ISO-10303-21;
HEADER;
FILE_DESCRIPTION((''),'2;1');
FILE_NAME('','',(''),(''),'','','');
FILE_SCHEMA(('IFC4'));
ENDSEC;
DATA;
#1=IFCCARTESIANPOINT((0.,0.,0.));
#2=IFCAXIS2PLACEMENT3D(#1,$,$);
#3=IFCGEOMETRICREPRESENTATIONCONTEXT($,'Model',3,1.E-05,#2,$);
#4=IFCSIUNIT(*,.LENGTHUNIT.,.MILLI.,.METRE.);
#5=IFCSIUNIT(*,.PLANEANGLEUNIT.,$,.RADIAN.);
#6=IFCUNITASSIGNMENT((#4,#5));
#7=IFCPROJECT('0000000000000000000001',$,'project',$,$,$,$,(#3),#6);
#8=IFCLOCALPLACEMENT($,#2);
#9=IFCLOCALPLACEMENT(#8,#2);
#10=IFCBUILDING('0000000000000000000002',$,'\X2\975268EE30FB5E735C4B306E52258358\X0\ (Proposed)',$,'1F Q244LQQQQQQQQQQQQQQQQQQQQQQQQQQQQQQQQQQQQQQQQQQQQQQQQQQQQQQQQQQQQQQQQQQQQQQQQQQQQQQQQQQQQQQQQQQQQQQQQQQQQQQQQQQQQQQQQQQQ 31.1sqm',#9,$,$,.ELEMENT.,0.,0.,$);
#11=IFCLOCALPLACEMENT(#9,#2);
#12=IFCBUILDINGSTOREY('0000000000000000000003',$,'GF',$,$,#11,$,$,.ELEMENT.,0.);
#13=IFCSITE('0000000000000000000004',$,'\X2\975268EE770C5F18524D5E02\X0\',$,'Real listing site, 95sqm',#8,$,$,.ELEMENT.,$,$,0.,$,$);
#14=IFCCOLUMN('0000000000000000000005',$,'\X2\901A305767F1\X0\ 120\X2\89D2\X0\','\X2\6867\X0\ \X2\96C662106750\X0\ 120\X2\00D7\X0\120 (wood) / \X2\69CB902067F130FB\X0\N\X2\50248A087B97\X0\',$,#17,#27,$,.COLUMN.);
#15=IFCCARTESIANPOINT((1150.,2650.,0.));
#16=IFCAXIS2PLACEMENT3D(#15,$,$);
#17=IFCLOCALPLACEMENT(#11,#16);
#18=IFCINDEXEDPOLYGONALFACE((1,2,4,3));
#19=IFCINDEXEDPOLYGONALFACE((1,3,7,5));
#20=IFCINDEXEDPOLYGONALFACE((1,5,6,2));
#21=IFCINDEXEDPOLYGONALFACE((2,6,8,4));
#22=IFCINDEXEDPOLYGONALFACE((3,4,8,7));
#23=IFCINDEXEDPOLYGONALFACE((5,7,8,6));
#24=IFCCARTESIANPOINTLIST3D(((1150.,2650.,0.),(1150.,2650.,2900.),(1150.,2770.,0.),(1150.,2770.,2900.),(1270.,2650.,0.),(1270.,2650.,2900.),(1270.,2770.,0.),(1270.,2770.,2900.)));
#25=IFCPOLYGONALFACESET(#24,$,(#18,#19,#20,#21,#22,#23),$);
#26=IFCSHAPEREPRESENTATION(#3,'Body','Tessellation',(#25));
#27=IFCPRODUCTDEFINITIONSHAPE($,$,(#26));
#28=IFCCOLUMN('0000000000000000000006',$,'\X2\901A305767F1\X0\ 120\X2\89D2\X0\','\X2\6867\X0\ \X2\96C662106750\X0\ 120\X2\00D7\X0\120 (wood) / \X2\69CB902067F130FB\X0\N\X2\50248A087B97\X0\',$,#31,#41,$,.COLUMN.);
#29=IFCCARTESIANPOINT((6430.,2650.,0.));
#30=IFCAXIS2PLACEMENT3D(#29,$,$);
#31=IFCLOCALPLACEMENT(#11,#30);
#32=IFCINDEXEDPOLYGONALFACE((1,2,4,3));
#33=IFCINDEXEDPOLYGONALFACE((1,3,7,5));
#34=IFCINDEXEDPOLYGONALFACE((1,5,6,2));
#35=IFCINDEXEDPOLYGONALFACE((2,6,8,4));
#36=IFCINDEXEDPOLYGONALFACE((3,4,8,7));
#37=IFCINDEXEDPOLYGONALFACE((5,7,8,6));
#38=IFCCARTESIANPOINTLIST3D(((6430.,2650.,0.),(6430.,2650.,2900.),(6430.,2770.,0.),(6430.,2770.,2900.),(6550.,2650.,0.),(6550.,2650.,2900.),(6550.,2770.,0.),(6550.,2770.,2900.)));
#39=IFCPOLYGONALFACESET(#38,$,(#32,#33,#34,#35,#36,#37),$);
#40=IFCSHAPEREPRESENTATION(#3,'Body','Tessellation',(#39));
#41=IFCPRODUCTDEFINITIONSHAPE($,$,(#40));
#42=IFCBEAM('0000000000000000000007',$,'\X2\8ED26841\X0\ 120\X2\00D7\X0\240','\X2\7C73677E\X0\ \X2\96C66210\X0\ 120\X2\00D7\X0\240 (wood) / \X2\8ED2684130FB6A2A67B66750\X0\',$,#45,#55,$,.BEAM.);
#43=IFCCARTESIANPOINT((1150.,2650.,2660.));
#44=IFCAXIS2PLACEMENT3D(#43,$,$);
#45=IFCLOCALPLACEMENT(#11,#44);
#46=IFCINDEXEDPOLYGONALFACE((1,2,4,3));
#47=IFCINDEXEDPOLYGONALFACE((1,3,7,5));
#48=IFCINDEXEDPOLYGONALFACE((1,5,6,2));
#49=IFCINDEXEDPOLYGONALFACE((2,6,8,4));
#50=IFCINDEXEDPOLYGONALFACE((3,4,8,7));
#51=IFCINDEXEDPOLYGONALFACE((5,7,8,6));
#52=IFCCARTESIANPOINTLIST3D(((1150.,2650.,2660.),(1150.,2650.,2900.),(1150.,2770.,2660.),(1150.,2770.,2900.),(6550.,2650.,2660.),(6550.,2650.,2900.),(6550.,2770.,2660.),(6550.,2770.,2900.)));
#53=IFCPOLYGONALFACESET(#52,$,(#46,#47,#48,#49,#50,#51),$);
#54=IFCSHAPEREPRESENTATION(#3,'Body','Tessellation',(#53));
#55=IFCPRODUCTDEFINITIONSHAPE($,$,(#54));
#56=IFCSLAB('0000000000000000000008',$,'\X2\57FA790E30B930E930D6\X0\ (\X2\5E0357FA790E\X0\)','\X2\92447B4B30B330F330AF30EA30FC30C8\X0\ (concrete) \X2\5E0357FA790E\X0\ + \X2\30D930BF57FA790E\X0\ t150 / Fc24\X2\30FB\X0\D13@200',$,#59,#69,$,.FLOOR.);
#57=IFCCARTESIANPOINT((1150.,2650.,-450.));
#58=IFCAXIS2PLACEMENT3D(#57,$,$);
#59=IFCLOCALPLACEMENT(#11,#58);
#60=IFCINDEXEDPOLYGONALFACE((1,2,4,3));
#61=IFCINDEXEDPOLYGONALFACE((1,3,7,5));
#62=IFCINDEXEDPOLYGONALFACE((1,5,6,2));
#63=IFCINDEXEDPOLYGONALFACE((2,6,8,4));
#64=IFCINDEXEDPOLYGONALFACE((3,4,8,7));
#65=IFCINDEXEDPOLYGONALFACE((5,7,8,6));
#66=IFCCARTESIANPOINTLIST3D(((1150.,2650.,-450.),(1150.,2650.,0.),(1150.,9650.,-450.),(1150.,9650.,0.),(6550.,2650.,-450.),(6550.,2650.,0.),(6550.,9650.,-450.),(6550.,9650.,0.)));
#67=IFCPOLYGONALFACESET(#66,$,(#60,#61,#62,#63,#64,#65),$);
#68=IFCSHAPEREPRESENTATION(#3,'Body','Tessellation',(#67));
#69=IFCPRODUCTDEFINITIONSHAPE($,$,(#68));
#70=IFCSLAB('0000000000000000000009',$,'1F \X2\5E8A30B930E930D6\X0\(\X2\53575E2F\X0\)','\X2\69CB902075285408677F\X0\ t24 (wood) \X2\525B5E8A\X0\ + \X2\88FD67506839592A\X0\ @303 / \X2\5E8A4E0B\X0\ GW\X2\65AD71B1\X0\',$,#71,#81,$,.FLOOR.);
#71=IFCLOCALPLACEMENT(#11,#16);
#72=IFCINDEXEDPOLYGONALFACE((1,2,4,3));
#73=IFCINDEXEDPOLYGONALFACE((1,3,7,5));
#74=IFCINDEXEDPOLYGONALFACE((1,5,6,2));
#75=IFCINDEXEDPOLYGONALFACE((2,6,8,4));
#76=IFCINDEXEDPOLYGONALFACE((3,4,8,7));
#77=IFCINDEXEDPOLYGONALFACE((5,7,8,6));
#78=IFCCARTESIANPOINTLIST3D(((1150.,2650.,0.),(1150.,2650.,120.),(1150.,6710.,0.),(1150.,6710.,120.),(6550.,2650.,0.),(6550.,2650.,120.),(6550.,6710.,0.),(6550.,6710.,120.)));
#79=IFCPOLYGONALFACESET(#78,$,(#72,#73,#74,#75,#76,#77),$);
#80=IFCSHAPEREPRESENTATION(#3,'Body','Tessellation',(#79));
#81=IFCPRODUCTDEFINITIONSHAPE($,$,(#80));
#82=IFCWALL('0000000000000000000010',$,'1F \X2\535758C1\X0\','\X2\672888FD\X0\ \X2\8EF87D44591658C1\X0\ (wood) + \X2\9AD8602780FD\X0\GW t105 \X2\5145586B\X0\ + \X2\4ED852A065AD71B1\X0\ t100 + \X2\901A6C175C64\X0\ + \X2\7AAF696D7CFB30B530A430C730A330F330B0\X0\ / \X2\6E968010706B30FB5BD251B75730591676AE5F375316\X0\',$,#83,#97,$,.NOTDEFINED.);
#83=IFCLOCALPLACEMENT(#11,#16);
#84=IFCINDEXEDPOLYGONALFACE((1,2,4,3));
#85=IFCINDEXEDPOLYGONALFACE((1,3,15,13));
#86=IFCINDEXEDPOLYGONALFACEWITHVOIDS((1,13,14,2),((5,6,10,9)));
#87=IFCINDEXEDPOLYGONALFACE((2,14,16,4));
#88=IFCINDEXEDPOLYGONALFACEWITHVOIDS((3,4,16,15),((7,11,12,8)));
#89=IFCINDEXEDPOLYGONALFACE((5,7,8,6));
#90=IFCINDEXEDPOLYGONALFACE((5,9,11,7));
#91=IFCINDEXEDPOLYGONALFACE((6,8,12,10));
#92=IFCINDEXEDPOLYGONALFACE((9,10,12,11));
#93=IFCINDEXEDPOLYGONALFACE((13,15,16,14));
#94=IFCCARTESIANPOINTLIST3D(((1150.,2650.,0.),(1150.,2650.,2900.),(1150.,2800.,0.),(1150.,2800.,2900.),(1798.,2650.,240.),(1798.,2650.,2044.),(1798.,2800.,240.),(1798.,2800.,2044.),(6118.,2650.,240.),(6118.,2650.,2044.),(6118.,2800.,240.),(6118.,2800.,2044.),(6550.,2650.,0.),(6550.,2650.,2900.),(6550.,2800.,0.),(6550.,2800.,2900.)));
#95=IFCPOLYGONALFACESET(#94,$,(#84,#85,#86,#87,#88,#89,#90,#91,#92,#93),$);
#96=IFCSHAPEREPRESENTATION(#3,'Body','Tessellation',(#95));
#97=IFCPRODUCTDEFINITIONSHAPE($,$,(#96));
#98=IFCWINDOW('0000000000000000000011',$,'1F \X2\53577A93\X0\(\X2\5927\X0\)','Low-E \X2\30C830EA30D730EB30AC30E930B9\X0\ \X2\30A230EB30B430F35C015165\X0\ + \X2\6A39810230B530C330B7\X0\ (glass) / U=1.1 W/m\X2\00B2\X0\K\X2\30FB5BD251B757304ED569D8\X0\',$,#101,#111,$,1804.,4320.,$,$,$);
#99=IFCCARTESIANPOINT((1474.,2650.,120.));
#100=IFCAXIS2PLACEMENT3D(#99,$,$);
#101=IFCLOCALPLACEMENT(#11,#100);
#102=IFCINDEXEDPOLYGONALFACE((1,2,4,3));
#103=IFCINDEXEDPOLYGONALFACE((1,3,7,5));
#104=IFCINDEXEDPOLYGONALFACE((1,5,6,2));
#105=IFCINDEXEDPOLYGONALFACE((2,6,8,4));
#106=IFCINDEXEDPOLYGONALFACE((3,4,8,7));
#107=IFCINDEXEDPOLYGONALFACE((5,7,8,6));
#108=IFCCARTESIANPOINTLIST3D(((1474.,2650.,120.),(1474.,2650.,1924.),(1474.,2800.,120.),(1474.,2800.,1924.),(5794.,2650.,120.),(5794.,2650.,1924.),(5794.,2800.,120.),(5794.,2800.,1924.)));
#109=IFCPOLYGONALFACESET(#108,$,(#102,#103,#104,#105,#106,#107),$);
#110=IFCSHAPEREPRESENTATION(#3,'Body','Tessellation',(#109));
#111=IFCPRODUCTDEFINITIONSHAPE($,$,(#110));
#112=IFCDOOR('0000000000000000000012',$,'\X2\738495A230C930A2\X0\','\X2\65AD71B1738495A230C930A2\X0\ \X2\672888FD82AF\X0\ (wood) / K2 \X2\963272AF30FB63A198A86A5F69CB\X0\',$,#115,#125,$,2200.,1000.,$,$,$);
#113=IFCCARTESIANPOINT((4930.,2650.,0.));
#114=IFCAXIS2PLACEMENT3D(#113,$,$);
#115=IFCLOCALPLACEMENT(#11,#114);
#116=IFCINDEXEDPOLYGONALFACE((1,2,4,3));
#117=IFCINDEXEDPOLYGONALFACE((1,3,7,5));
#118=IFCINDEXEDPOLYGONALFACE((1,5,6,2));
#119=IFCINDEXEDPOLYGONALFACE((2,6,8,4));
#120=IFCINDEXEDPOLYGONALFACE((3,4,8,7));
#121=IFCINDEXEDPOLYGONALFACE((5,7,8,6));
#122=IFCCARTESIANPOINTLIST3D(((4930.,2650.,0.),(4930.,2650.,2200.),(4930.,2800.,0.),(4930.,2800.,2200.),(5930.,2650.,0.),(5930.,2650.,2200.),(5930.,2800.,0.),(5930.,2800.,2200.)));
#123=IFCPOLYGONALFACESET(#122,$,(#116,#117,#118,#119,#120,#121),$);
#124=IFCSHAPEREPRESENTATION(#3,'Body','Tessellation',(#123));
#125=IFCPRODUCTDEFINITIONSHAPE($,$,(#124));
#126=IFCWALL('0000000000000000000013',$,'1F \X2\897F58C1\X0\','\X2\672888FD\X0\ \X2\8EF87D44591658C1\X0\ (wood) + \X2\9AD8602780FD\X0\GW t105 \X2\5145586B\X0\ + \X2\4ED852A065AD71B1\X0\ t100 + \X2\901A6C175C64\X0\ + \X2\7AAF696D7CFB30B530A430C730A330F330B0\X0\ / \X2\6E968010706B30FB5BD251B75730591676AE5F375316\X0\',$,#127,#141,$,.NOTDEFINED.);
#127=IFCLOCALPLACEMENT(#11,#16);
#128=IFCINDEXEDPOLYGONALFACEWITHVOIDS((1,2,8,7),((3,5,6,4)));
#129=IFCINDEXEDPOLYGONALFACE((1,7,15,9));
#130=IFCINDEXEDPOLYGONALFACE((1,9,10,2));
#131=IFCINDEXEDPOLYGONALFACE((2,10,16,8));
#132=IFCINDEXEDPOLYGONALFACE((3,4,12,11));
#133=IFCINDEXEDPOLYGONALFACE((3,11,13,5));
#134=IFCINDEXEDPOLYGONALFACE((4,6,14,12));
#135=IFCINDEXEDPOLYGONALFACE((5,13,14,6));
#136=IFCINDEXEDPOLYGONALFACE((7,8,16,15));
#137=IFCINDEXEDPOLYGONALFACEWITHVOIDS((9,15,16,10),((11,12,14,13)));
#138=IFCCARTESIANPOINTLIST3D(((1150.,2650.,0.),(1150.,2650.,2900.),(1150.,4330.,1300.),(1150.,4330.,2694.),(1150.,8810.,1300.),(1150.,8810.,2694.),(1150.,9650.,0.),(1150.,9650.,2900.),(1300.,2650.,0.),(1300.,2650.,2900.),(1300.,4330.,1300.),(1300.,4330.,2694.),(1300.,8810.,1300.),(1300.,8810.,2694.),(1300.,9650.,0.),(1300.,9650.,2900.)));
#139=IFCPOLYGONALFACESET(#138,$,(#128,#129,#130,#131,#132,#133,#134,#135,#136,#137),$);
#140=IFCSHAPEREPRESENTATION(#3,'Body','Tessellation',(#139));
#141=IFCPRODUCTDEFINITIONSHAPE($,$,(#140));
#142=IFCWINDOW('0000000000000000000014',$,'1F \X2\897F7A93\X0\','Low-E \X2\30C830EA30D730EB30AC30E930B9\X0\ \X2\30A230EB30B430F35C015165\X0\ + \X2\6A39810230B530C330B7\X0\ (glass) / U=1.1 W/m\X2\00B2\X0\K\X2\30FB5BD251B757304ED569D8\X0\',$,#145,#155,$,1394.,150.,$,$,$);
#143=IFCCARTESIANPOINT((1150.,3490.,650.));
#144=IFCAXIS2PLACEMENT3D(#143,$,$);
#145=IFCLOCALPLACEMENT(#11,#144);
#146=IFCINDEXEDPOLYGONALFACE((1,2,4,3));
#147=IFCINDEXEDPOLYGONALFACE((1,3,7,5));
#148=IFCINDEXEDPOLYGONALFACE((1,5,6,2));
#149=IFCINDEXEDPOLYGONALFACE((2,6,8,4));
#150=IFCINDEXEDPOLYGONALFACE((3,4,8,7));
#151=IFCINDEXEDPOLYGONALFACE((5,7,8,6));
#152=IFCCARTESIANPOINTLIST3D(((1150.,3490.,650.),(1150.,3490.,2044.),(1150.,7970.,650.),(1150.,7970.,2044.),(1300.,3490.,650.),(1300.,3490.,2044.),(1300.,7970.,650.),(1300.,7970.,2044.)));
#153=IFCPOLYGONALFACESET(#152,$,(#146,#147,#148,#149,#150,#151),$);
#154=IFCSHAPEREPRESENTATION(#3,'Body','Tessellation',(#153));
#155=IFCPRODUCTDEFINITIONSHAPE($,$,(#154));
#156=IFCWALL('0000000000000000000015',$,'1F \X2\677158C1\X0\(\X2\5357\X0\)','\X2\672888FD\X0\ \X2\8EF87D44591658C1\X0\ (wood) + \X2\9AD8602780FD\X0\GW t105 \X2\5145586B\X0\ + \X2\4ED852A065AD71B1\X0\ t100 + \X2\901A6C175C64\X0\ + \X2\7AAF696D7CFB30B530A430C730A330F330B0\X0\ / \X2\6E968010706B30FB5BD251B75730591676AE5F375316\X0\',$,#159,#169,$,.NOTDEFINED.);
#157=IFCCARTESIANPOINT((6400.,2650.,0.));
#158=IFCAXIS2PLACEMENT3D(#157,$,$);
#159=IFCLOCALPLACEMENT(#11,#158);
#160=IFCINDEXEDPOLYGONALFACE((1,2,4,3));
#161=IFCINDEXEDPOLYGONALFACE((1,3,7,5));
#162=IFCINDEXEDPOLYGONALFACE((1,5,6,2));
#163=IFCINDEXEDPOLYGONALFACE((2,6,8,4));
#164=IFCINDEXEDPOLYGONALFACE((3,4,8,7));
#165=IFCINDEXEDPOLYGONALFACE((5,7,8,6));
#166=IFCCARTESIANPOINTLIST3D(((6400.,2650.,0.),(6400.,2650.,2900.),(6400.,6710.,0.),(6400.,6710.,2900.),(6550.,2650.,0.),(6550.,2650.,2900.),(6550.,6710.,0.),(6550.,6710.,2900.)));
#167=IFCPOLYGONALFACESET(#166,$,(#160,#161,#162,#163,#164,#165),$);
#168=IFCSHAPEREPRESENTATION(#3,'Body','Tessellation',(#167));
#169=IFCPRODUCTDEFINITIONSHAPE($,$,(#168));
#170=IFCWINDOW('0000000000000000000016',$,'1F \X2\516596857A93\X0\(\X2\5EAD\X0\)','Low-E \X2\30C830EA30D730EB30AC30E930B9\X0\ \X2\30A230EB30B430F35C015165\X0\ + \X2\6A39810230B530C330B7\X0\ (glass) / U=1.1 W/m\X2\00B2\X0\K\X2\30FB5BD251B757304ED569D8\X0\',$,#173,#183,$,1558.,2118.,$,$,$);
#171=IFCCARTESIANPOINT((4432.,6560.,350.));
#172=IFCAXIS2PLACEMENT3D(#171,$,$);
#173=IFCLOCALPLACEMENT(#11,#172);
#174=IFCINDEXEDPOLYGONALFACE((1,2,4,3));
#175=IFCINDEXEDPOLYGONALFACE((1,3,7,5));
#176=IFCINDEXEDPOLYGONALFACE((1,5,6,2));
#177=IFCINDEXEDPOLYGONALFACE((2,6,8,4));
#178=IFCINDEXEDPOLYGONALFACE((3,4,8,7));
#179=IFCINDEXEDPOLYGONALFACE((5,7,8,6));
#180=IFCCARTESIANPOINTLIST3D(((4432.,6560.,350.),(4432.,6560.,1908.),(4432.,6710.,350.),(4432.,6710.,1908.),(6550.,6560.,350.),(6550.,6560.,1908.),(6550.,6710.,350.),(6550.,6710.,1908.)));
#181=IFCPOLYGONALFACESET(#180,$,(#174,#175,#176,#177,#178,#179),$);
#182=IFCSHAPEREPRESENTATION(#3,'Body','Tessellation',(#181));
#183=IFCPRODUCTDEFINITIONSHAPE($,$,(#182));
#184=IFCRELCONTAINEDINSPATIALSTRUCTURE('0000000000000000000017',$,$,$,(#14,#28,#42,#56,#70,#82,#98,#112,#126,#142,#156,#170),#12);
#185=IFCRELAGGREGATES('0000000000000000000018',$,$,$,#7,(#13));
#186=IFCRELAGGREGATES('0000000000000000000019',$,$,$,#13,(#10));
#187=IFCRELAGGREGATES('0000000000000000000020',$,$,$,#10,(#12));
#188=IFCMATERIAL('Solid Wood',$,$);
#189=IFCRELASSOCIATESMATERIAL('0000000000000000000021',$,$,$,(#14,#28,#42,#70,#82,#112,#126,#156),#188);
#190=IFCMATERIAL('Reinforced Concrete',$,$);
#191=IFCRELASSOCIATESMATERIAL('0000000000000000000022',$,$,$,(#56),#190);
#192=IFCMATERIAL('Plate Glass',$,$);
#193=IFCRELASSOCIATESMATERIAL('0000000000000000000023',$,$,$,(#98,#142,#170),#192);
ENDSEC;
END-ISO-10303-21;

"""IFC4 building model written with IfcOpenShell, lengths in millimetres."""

from ifc_helpers import new_model, si_unit, frame, frame_2d, origin, place, context, project, spatial, rectangle, extrude, material, element, fill, save


model = new_model("IFC4")

# Units and contexts
model_context = context("Model", 3, precision=1e-05, world=origin())
ifc_project = project(units=[si_unit("LENGTHUNIT", "METRE", prefix="MILLI"), si_unit("PLANEANGLEUNIT", "RADIAN")], contexts=[model_context])

# Site, building, storey
site_placement = place(None, origin())
site = spatial("IfcSite", under=ifc_project, at=site_placement, Name="青森県弘前市", ObjectType="Real listing site, 95sqm", CompositionType="ELEMENT", RefElevation=0.0)
building_placement = place(site_placement, origin())
building = spatial("IfcBuilding", under=site, at=building_placement, Name="青森・平屋の別荘 (Proposed)", ObjectType="1F Q244LQQQQQQQQQQQQQQQQQQQQQQQQQQQQQQQQQQQQQQQQQQQQQQQQQQQQQQQQQQQQQQQQQQQQQQQQQQQQQQQQQQQQQQQQQQQQQQQQQQQQQQQQQQQQQQQQQQQ 31.1sqm", CompositionType="ELEMENT", ElevationOfRefHeight=0.0, ElevationOfTerrain=0.0)
storey_placement = place(building_placement, origin())
storey = spatial("IfcBuildingStorey", under=building, at=storey_placement, Name="GF", CompositionType="ELEMENT", Elevation=0.0)

# Columns
ifc_material_1 = material(Name="Solid Wood")
column_1_placement = place(storey_placement, frame((1150.0, 2650.0, 0.0)))
element("IfcColumn", 1, at=column_1_placement, inside=storey, material=ifc_material_1, Name="通し柱 120角", Description="桧 集成材 120×120 (wood) / 構造柱・N値計算", PredefinedType="COLUMN", context=model_context, shape_type="SweptSolid", body=[
    extrude(rectangle(XDim=120.0, YDim=120.0, at=frame_2d((60.0, 60.0))), frame((1150.0, 2650.0, 0.0)), (0.0, 0.0, 1.0), 2900.0),
])
column_2_placement = place(storey_placement, frame((6430.0, 2650.0, 0.0)))
element("IfcColumn", 2, at=column_2_placement, inside=storey, material=ifc_material_1, Name="通し柱 120角", Description="桧 集成材 120×120 (wood) / 構造柱・N値計算", PredefinedType="COLUMN", context=model_context, shape_type="SweptSolid", body=[
    extrude(rectangle(XDim=120.0, YDim=120.0, at=frame_2d((60.0, 60.0))), frame((6430.0, 2650.0, 0.0)), (0.0, 0.0, 1.0), 2900.0),
])

# Beam
beam_1_placement = place(storey_placement, frame((1150.0, 2650.0, 2660.0)))
element("IfcBeam", 3, at=beam_1_placement, inside=storey, material=ifc_material_1, Name="軒桁 120×240", Description="米松 集成 120×240 (wood) / 軒桁・横架材", PredefinedType="BEAM", context=model_context, shape_type="SweptSolid", body=[
    extrude(rectangle(XDim=5400.0, YDim=120.0, at=frame_2d((2700.0, 60.0))), frame((1150.0, 2650.0, 2660.0)), (0.0, 0.0, 1.0), 240.0),
])

# Slabs
ifc_material_2 = material(Name="Reinforced Concrete")
slab_1_placement = place(storey_placement, frame((1150.0, 2650.0, -450.0)))
element("IfcSlab", 4, at=slab_1_placement, inside=storey, material=ifc_material_2, Name="基礎スラブ (布基礎)", Description="鉄筋コンクリート (concrete) 布基礎 + ベタ基礎 t150 / Fc24・D13@200", PredefinedType="FLOOR", context=model_context, shape_type="SweptSolid", body=[
    extrude(rectangle(XDim=5400.0, YDim=7000.0, at=frame_2d((2700.0, 3500.0))), frame((1150.0, 2650.0, -450.0)), (0.0, 0.0, 1.0), 450.0),
])
slab_2_placement = place(storey_placement, frame((1150.0, 2650.0, 0.0)))
element("IfcSlab", 5, at=slab_2_placement, inside=storey, material=ifc_material_1, Name="1F 床スラブ(南帯)", Description="構造用合板 t24 (wood) 剛床 + 製材根太 @303 / 床下 GW断熱", PredefinedType="FLOOR", context=model_context, shape_type="SweptSolid", body=[
    extrude(rectangle(XDim=5400.0, YDim=4060.0, at=frame_2d((2700.0, 2030.0))), frame((1150.0, 2650.0, 0.0)), (0.0, 0.0, 1.0), 120.0),
])

# Wall, openings, window, door
wall_1_placement = place(storey_placement, frame((1150.0, 2650.0, 0.0)))
wall_1 = element("IfcWall", 6, at=wall_1_placement, inside=storey, material=ifc_material_1, Name="1F 南壁", Description="木製 軸組外壁 (wood) + 高性能GW t105 充填 + 付加断熱 t100 + 通気層 + 窯業系サイディング / 準耐火・寒冷地外皮強化", PredefinedType="NOTDEFINED", context=model_context, shape_type="SweptSolid", body=[
    extrude(rectangle(XDim=5400.0, YDim=150.0, at=frame_2d((2700.0, 75.0))), frame((1150.0, 2650.0, 0.0)), (0.0, 0.0, 1.0), 2900.0),
])
opening_1_placement = place(storey_placement, frame((1474.0, 2650.0, 120.0)))
opening_1 = element("IfcOpeningElement", 7, at=opening_1_placement, cuts=wall_1, PredefinedType="NOTDEFINED", context=model_context, shape_type="SweptSolid", body=[
    extrude(rectangle(XDim=4320.0, YDim=150.0, at=frame_2d((2160.0, 75.0))), frame((1474.0, 2650.0, 120.0)), (0.0, 0.0, 1.0), 1804.0),
])
opening_2_placement = place(storey_placement, frame((4930.0, 2650.0, 0.0)))
opening_2 = element("IfcOpeningElement", 8, at=opening_2_placement, cuts=wall_1, PredefinedType="NOTDEFINED", context=model_context, shape_type="SweptSolid", body=[
    extrude(rectangle(XDim=1000.0, YDim=150.0, at=frame_2d((500.0, 75.0))), frame((4930.0, 2650.0, 0.0)), (0.0, 0.0, 1.0), 2200.0),
])
ifc_material_3 = material(Name="Plate Glass")
window_1_placement = place(storey_placement, frame((1474.0, 2650.0, 120.0)))
window_1 = element("IfcWindow", 9, at=window_1_placement, inside=storey, material=ifc_material_3, Name="1F 南窓(大)", Description="Low-E トリプルガラス アルゴン封入 + 樹脂サッシ (glass) / U=1.1 W/m²K・寒冷地仕様", OverallHeight=1804.0, OverallWidth=4320.0, context=model_context, shape_type="SweptSolid", body=[
    extrude(rectangle(XDim=4320.0, YDim=150.0, at=frame_2d((2160.0, 75.0))), frame((1474.0, 2650.0, 120.0)), (0.0, 0.0, 1.0), 1804.0),
])
fill(opening_1, window_1)
door_1_placement = place(storey_placement, frame((4930.0, 2650.0, 0.0)))
door_1 = element("IfcDoor", 10, at=door_1_placement, inside=storey, material=ifc_material_1, Name="玄関ドア", Description="断熱玄関ドア 木製芯 (wood) / K2 防犯・採風機構", OverallHeight=2200.0, OverallWidth=1000.0, context=model_context, shape_type="SweptSolid", body=[
    extrude(rectangle(XDim=1000.0, YDim=150.0, at=frame_2d((500.0, 75.0))), frame((4930.0, 2650.0, 0.0)), (0.0, 0.0, 1.0), 2200.0),
])
fill(opening_2, door_1)

# Walls, openings, windows
wall_2_placement = place(storey_placement, frame((1150.0, 2650.0, 0.0)))
wall_2 = element("IfcWall", 11, at=wall_2_placement, inside=storey, material=ifc_material_1, Name="1F 西壁", Description="木製 軸組外壁 (wood) + 高性能GW t105 充填 + 付加断熱 t100 + 通気層 + 窯業系サイディング / 準耐火・寒冷地外皮強化", PredefinedType="NOTDEFINED", context=model_context, shape_type="SweptSolid", body=[
    extrude(rectangle(XDim=150.0, YDim=7000.0, at=frame_2d((75.0, 3500.0))), frame((1150.0, 2650.0, 0.0)), (0.0, 0.0, 1.0), 2900.0),
])
opening_3_placement = place(storey_placement, frame((1150.0, 3490.0, 650.0)))
opening_3 = element("IfcOpeningElement", 12, at=opening_3_placement, cuts=wall_2, PredefinedType="NOTDEFINED", context=model_context, shape_type="SweptSolid", body=[
    extrude(rectangle(XDim=150.0, YDim=4480.0, at=frame_2d((75.0, 2240.0))), frame((1150.0, 3490.0, 650.0)), (0.0, 0.0, 1.0), 1394.0),
])
window_2_placement = place(storey_placement, frame((1150.0, 3490.0, 650.0)))
window_2 = element("IfcWindow", 13, at=window_2_placement, inside=storey, material=ifc_material_3, Name="1F 西窓", Description="Low-E トリプルガラス アルゴン封入 + 樹脂サッシ (glass) / U=1.1 W/m²K・寒冷地仕様", OverallHeight=1394.0, OverallWidth=150.0, context=model_context, shape_type="SweptSolid", body=[
    extrude(rectangle(XDim=150.0, YDim=4480.0, at=frame_2d((75.0, 2240.0))), frame((1150.0, 3490.0, 650.0)), (0.0, 0.0, 1.0), 1394.0),
])
fill(opening_3, window_2)
wall_3_placement = place(storey_placement, frame((6400.0, 2650.0, 0.0)))
wall_3 = element("IfcWall", 14, at=wall_3_placement, inside=storey, material=ifc_material_1, Name="1F 東壁(南)", Description="木製 軸組外壁 (wood) + 高性能GW t105 充填 + 付加断熱 t100 + 通気層 + 窯業系サイディング / 準耐火・寒冷地外皮強化", PredefinedType="NOTDEFINED", context=model_context, shape_type="SweptSolid", body=[
    extrude(rectangle(XDim=150.0, YDim=4060.0, at=frame_2d((75.0, 2030.0))), frame((6400.0, 2650.0, 0.0)), (0.0, 0.0, 1.0), 2900.0),
])
opening_4_placement = place(storey_placement, frame((4432.0, 6560.0, 350.0)))
opening_4 = element("IfcOpeningElement", 15, at=opening_4_placement, cuts=wall_3, PredefinedType="NOTDEFINED", context=model_context, shape_type="SweptSolid", body=[
    extrude(rectangle(XDim=2118.0, YDim=150.0, at=frame_2d((1059.0, 75.0))), frame((4432.0, 6560.0, 350.0)), (0.0, 0.0, 1.0), 1558.0),
])
window_3_placement = place(storey_placement, frame((4432.0, 6560.0, 350.0)))
window_3 = element("IfcWindow", 16, at=window_3_placement, inside=storey, material=ifc_material_3, Name="1F 入隅窓(庭)", Description="Low-E トリプルガラス アルゴン封入 + 樹脂サッシ (glass) / U=1.1 W/m²K・寒冷地仕様", OverallHeight=1558.0, OverallWidth=2118.0, context=model_context, shape_type="SweptSolid", body=[
    extrude(rectangle(XDim=2118.0, YDim=150.0, at=frame_2d((1059.0, 75.0))), frame((4432.0, 6560.0, 350.0)), (0.0, 0.0, 1.0), 1558.0),
])
fill(opening_4, window_3)

save(model, "model.ifc")
